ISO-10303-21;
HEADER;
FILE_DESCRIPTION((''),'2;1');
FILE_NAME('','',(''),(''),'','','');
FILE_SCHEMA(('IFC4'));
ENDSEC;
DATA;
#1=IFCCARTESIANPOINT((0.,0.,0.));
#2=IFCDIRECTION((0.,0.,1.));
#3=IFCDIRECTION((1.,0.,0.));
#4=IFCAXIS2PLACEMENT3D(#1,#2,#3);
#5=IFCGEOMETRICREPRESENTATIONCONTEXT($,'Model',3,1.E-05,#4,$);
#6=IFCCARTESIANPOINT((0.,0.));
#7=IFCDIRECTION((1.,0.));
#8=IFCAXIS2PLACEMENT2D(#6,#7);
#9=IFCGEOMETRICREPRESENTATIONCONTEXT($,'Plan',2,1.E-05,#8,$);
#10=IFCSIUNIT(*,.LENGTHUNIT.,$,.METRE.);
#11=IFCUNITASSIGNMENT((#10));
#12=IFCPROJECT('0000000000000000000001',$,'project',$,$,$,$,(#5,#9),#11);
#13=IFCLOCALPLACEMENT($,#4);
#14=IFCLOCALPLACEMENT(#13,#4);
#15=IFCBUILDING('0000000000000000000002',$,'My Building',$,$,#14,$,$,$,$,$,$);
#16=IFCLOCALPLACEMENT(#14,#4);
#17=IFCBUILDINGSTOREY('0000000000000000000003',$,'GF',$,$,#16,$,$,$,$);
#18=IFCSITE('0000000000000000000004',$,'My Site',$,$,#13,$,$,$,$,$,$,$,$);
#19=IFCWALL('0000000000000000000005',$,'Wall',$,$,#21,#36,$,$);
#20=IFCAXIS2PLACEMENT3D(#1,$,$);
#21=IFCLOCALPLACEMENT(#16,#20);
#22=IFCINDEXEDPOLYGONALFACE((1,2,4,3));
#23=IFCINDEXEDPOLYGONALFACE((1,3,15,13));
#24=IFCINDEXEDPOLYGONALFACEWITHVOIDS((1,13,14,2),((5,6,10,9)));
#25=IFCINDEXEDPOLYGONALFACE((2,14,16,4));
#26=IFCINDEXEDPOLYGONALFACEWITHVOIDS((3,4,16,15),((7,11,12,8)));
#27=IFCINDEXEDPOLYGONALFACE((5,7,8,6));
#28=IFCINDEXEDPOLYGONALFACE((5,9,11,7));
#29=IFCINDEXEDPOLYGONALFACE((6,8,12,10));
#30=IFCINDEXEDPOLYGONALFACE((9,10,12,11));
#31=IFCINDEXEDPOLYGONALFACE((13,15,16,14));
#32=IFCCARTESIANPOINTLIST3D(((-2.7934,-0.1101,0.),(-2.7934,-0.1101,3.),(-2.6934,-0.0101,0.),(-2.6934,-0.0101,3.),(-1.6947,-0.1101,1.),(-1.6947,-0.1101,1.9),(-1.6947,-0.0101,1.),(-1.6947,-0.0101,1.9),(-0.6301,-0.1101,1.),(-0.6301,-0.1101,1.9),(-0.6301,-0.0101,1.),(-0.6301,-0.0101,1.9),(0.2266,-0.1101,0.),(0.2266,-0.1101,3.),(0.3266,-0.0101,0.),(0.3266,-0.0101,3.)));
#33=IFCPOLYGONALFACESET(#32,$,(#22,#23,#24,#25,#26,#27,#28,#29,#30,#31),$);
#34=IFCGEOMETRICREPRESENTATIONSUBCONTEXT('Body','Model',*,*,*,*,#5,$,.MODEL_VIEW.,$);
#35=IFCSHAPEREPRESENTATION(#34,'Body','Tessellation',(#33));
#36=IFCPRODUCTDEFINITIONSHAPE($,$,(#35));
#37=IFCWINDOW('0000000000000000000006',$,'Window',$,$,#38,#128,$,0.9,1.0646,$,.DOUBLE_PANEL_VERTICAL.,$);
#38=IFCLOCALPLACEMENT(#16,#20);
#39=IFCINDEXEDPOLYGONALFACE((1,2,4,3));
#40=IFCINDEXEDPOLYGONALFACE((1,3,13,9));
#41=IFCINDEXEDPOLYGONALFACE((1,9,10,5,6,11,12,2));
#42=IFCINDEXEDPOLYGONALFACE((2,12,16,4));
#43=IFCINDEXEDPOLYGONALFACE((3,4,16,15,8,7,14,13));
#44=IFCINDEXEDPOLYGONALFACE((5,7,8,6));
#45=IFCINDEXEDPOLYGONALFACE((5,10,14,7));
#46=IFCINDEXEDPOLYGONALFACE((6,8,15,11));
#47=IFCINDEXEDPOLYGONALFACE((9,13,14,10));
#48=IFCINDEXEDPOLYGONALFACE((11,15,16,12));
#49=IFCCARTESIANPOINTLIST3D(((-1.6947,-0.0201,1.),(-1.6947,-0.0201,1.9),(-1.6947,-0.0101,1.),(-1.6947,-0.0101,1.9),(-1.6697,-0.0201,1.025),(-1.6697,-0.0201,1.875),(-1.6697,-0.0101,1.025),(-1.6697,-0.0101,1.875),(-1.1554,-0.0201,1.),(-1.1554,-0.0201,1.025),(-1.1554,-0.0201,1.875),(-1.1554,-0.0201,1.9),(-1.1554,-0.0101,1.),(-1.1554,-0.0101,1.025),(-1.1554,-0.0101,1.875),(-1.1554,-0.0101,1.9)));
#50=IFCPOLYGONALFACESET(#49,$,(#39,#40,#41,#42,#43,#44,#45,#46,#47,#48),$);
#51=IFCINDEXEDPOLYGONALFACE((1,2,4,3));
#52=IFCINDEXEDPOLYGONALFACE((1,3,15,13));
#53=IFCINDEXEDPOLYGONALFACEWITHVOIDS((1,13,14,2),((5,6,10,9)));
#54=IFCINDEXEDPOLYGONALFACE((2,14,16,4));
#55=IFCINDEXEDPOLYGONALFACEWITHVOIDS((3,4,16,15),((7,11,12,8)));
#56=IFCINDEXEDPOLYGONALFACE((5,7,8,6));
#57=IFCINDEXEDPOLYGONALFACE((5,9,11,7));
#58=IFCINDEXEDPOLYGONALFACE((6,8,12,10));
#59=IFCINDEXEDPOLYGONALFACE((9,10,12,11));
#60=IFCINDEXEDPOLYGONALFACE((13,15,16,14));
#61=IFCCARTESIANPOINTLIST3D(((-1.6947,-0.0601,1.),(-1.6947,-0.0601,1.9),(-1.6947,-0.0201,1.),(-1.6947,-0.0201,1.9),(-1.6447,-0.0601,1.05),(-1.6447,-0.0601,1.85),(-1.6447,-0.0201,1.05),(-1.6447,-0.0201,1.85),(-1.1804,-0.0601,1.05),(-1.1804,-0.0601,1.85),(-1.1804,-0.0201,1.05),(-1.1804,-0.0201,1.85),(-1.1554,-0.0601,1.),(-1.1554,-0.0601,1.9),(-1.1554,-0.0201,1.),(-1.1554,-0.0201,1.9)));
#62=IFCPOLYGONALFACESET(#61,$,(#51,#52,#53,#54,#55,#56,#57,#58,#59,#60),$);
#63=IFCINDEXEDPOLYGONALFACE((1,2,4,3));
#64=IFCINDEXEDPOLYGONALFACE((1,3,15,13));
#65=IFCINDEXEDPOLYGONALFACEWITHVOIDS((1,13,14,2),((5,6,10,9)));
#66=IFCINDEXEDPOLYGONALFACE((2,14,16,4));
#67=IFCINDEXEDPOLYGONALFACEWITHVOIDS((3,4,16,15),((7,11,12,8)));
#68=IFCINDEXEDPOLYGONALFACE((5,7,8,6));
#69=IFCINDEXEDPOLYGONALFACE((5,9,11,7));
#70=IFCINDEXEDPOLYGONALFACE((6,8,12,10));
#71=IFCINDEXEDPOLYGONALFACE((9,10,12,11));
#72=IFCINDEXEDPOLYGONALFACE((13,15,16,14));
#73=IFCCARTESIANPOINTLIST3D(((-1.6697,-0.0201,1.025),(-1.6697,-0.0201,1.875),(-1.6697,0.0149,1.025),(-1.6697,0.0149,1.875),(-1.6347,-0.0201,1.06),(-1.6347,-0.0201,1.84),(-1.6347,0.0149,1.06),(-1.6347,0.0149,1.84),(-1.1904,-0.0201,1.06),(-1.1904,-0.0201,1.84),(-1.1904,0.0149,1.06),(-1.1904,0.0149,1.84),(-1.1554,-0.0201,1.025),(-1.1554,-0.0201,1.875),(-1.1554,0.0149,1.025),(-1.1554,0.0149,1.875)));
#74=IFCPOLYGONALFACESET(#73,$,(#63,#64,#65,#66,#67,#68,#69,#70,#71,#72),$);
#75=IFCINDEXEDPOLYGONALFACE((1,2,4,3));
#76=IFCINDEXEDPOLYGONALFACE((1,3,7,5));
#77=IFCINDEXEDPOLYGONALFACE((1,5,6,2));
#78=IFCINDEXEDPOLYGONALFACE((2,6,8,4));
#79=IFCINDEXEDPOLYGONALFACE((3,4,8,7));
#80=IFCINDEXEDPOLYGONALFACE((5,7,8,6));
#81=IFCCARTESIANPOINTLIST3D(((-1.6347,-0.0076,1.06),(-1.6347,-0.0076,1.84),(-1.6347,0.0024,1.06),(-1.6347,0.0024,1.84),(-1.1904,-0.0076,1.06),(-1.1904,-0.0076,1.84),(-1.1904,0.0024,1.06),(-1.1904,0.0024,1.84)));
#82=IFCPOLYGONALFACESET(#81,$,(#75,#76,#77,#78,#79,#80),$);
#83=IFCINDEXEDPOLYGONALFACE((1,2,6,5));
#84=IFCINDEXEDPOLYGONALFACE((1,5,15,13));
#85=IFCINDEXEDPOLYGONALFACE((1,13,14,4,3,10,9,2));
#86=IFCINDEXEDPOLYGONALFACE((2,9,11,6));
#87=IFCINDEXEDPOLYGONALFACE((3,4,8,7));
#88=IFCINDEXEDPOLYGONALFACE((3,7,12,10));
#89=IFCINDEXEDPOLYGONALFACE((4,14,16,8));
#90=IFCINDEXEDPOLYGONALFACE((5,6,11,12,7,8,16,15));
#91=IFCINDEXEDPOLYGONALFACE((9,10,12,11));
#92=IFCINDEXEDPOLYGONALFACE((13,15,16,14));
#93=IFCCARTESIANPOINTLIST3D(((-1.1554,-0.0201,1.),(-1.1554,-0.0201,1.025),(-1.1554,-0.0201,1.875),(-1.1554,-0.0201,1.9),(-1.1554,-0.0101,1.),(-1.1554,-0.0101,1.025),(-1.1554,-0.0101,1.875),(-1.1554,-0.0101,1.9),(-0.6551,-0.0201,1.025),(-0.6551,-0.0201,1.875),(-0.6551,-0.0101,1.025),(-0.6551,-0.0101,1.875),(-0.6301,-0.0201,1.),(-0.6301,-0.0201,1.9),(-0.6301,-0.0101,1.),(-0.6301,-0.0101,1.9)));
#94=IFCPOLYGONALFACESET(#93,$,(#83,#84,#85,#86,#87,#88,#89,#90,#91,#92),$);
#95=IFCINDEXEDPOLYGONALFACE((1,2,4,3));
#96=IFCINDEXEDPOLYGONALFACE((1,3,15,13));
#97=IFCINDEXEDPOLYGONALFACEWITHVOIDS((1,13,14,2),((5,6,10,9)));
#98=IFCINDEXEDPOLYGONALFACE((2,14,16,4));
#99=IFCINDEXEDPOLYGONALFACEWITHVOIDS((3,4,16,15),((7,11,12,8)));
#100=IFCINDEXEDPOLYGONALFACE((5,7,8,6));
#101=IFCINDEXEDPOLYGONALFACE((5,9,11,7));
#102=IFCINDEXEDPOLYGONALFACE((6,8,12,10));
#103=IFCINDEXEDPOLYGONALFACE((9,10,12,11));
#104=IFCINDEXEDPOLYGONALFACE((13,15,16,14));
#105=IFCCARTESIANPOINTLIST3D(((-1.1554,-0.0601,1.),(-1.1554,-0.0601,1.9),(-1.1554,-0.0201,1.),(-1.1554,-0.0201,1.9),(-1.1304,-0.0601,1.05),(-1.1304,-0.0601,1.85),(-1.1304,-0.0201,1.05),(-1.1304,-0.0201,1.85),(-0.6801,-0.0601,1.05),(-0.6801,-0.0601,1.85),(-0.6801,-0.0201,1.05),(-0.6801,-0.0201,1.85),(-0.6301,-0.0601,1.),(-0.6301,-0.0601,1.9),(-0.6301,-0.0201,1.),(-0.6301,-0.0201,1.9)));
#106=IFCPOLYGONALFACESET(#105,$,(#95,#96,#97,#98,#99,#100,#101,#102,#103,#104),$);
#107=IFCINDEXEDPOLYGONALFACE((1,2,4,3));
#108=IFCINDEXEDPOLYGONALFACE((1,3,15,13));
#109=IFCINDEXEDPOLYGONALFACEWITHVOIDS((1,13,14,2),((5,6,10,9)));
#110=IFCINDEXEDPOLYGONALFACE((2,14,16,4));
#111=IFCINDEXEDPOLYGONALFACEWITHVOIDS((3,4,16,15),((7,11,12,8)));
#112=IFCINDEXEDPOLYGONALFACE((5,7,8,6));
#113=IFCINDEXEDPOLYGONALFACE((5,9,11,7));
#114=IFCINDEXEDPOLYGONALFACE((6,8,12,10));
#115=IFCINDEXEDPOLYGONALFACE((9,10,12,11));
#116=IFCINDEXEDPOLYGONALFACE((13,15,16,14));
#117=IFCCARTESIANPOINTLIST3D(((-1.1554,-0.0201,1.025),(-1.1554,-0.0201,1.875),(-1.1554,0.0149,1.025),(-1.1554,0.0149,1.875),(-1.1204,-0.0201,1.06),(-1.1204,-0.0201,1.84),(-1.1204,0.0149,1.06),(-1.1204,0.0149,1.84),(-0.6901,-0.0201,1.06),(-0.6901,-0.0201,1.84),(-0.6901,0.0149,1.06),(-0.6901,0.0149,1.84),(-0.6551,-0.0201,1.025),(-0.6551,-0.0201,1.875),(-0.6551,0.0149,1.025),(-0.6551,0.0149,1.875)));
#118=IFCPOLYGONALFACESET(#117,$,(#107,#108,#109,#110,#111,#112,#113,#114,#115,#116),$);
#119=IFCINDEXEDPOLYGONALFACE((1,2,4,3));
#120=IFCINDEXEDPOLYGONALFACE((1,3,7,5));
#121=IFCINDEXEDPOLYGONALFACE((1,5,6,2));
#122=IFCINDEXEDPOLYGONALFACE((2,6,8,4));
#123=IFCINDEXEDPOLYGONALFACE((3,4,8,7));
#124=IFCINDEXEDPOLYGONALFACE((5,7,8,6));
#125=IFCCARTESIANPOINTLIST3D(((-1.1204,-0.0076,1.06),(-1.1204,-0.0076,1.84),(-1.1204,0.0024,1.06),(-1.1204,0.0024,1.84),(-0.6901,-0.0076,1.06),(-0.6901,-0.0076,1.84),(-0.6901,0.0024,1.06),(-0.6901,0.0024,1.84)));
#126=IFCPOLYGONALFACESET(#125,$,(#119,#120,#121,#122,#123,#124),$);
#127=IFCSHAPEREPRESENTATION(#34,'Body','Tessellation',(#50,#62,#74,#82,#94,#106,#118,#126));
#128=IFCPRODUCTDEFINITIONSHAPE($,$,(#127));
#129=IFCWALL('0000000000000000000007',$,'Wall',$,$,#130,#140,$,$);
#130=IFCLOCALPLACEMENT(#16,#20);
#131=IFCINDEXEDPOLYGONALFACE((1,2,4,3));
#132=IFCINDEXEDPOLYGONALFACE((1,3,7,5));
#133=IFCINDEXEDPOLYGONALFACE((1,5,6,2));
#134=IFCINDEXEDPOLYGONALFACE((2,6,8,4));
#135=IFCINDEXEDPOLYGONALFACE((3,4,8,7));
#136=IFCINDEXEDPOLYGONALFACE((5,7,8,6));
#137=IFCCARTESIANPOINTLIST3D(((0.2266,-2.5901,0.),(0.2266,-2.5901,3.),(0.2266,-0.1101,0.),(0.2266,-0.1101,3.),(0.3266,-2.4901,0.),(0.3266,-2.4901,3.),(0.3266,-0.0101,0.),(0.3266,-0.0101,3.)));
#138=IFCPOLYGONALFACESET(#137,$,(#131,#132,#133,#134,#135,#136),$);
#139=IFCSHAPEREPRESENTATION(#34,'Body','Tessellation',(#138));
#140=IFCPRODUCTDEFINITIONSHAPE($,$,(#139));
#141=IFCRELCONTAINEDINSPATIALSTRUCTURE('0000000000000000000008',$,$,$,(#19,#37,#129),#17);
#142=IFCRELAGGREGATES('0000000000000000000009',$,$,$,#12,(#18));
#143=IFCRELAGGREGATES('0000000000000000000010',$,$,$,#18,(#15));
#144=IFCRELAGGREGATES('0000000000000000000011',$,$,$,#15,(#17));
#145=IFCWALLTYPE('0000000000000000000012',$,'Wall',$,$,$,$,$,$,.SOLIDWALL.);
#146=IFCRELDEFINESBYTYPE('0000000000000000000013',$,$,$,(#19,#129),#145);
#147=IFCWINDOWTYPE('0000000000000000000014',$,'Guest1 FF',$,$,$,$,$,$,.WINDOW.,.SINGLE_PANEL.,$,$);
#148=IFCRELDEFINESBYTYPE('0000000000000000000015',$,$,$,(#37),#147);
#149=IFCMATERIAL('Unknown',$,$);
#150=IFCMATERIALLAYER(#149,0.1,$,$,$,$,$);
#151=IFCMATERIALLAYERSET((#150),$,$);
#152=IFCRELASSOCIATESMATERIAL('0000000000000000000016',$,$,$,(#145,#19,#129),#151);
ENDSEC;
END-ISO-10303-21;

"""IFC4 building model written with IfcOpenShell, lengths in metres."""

from ifc_helpers import new_model, entity, si_unit, frame, origin_with_axes, origin_2d_with_axis, place, context, subcontext, project, spatial, line, indexed_curve, outline, extrude, shape, source, transform, mapped, material, layer, layer_set, layer_usage, type_object, type_shapes, element, fill, save


model = new_model("IFC4")

# Units and contexts
model_context = context("Model", 3, precision=1e-05, world=origin_with_axes())
plan_context = context("Plan", 2, precision=1e-05, world=origin_2d_with_axis())
body_context_1 = subcontext(model_context, "Body", "Model", "MODEL_VIEW")
body_context_2 = subcontext(plan_context, "Body", "Plan", "PLAN_VIEW")
ifc_project = project(units=[si_unit("LENGTHUNIT", "METRE")], contexts=[model_context, plan_context])

# Site, building, storey
site_placement = place(None, origin_with_axes())
site = spatial("IfcSite", under=ifc_project, at=site_placement, Name="My Site")
building_placement = place(site_placement, origin_with_axes())
building = spatial("IfcBuilding", under=site, at=building_placement, Name="My Building")
storey_placement = place(building_placement, origin_with_axes())
storey = spatial("IfcBuildingStorey", under=building, at=storey_placement, Name="GF")

# Shared definitions
ifc_material = material(Name="Unknown")
ifc_layer = layer(ifc_material, 0.1)
ifc_layer_set = layer_set([ifc_layer])
wall_type = type_object("IfcWallType", Name="Wall", PredefinedType="SOLIDWALL", material=ifc_layer_set)

# Wall, opening, window
ifc_layer_usage_1 = layer_usage(ifc_layer_set, "AXIS2", "POSITIVE", 0.0)
wall_1_placement = place(storey_placement, frame((-2.7934, -0.1101, 0.0), z_axis=(0.0, 0.0, 1.0), x_axis=(1.0, 0.0, 0.0)))
wall_1 = element("IfcWall", 1, at=wall_1_placement, inside=storey, type_object=wall_type, material=ifc_layer_usage_1, Name="Wall", context=body_context_1, shape_type="SweptSolid", body=[
    extrude(outline(indexed_curve([(0.0, 0.0), (0.1, 0.1), (3.12, 0.1), (3.02, 0.0)], segments=[line(1, 2, 3, 4, 1)])), origin_with_axes(), (0.0, 0.0, 1.0), 3.0),
])
shared_shape_1 = source(origin_with_axes(), body_context_1, "Body", "SweptSolid", [
    extrude(outline(indexed_curve([(0.0, 0.0), (1.0646, 0.0), (1.0646, 0.9), (0.0, 0.9)], segments=[line(1, 2, 3, 4, 1)])), frame((0.0, -0.6, 0.0), z_axis=(0.0, -1.0, 0.0), x_axis=(1.0, 0.0, 0.0)), (0.0, 0.0, -1.0), 1.2),
])
opening_1_placement = place(wall_1_placement, frame((1.0987, 0.0, 1.0), z_axis=(0.0, 0.0, 1.0), x_axis=(1.0, 0.0, 0.0)))
opening_1 = element("IfcOpeningElement", 2, at=opening_1_placement, cuts=wall_1, PredefinedType="OPENING", context=body_context_1, shape_type="MappedRepresentation", body=[
    mapped(shared_shape_1, transform((0.0, 0.0, 0.0), x_axis=(1.0, 0.0, 0.0), y_axis=(0.0, 1.0, 0.0), z_axis=(0.0, 0.0, 1.0), scale=1.0)),
])
window_type_1 = type_object("IfcWindowType", Name="Guest1 FF", PartitioningType="SINGLE_PANEL", PredefinedType="WINDOW")
shared_shape_2 = source(origin_with_axes(), body_context_1, "Body", "SweptSolid", [
    extrude(outline(indexed_curve([(0.5393, 0.0), (0.0, 0.0), (0.0, 0.9), (0.5393, 0.9), (0.5393, 0.875), (0.025, 0.875), (0.025, 0.025), (0.5393, 0.025)], segments=[line(1, 2, 3, 4, 5, 6, 7, 8, 1)])), frame((0.0, 0.09, 0.0), z_axis=(0.0, -1.0, 0.0), x_axis=(1.0, 0.0, 0.0)), (0.0, 0.0, -1.0), 0.01),
    extrude(outline(indexed_curve([(0.0, 0.0), (0.5393, 0.0), (0.5393, 0.9), (0.0, 0.9)], segments=[line(1, 2, 3, 4, 1)]), holes=[indexed_curve([(0.05, 0.05), (0.5143, 0.05), (0.5143, 0.85), (0.05, 0.85)], segments=[line(1, 2, 3, 4, 1)])]), frame((0.0, 0.05, 0.0), z_axis=(0.0, -1.0, 0.0), x_axis=(1.0, 0.0, 0.0)), (0.0, 0.0, -1.0), 0.04),
    extrude(outline(indexed_curve([(0.0, 0.0), (0.5143, 0.0), (0.5143, 0.85), (0.0, 0.85)], segments=[line(1, 2, 3, 4, 1)]), holes=[indexed_curve([(0.035, 0.035), (0.4793, 0.035), (0.4793, 0.815), (0.035, 0.815)], segments=[line(1, 2, 3, 4, 1)])]), frame((0.025, 0.09, 0.025), z_axis=(0.0, -1.0, 0.0), x_axis=(1.0, 0.0, 0.0)), (0.0, 0.0, -1.0), 0.035),
    extrude(outline(indexed_curve([(0.035, 0.035), (0.4793, 0.035), (0.4793, 0.815), (0.035, 0.815)], segments=[line(1, 2, 3, 4, 1)])), frame((0.025, 0.1025, 0.025), z_axis=(0.0, -1.0, 0.0), x_axis=(1.0, 0.0, 0.0)), (0.0, 0.0, -1.0), 0.01),
    extrude(outline(indexed_curve([(0.0, 0.9), (0.5253, 0.9), (0.5253, 0.0), (0.0, 0.0), (0.0, 0.025), (0.5003, 0.025), (0.5003, 0.875), (0.0, 0.875)], segments=[line(1, 2, 3, 4, 5, 6, 7, 8, 1)])), frame((0.5393, 0.09, 0.0), z_axis=(0.0, -1.0, 0.0), x_axis=(1.0, 0.0, 0.0)), (0.0, 0.0, -1.0), 0.01),
    extrude(outline(indexed_curve([(0.0, 0.0), (0.5253, 0.0), (0.5253, 0.9), (0.0, 0.9)], segments=[line(1, 2, 3, 4, 1)]), holes=[indexed_curve([(0.025, 0.05), (0.4753, 0.05), (0.4753, 0.85), (0.025, 0.85)], segments=[line(1, 2, 3, 4, 1)])]), frame((0.5393, 0.05, 0.0), z_axis=(0.0, -1.0, 0.0), x_axis=(1.0, 0.0, 0.0)), (0.0, 0.0, -1.0), 0.04),
    extrude(outline(indexed_curve([(0.0, 0.0), (0.5003, 0.0), (0.5003, 0.85), (0.0, 0.85)], segments=[line(1, 2, 3, 4, 1)]), holes=[indexed_curve([(0.035, 0.035), (0.4653, 0.035), (0.4653, 0.815), (0.035, 0.815)], segments=[line(1, 2, 3, 4, 1)])]), frame((0.5393, 0.09, 0.025), z_axis=(0.0, -1.0, 0.0), x_axis=(1.0, 0.0, 0.0)), (0.0, 0.0, -1.0), 0.035),
    extrude(outline(indexed_curve([(0.035, 0.035), (0.4653, 0.035), (0.4653, 0.815), (0.035, 0.815)], segments=[line(1, 2, 3, 4, 1)])), frame((0.5393, 0.1025, 0.025), z_axis=(0.0, -1.0, 0.0), x_axis=(1.0, 0.0, 0.0)), (0.0, 0.0, -1.0), 0.01),
])
shared_shape_3 = source(origin_with_axes(), body_context_2, "Body", "Curve2D", [
    entity("IfcIndexedPolyCurve", entity("IfcCartesianPointList2D", [[0.05, 0.05], [0.5143, 0.05]])),
    entity("IfcIndexedPolyCurve", entity("IfcCartesianPointList2D", [[0.0, 0.1], [0.025, 0.1], [0.025, 0.09], [0.05, 0.09], [0.05, 0.05], [0.0, 0.05]]), [entity("IfcLineIndex", [1, 2, 3, 4, 5, 6, 1])]),
    entity("IfcIndexedPolyCurve", entity("IfcCartesianPointList2D", [[0.5393, 0.1], [0.5393, 0.1], [0.5393, 0.09], [0.5143, 0.09], [0.5143, 0.05], [0.5393, 0.05]])),
    entity("IfcIndexedPolyCurve", entity("IfcCartesianPointList2D", [[0.025, 0.09], [0.06, 0.09], [0.06, 0.125], [0.025, 0.125]]), [entity("IfcLineIndex", [1, 2, 3, 4, 1])]),
    entity("IfcIndexedPolyCurve", entity("IfcCartesianPointList2D", [[0.5393, 0.09], [0.5043, 0.09], [0.5043, 0.125], [0.5393, 0.125]]), [entity("IfcLineIndex", [1, 2, 3, 4, 1])]),
    entity("IfcIndexedPolyCurve", entity("IfcCartesianPointList2D", [[0.06, 0.09], [0.5043, 0.09]])),
    entity("IfcIndexedPolyCurve", entity("IfcCartesianPointList2D", [[0.06, 0.125], [0.5043, 0.125]])),
    entity("IfcIndexedPolyCurve", entity("IfcCartesianPointList2D", [[0.06, 0.1075], [0.5043, 0.1075]])),
    entity("IfcIndexedPolyCurve", entity("IfcCartesianPointList2D", [[0.5643, 0.05], [1.0146, 0.05]])),
    entity("IfcIndexedPolyCurve", entity("IfcCartesianPointList2D", [[0.5393, 0.1], [0.5393, 0.1], [0.5393, 0.09], [0.5643, 0.09], [0.5643, 0.05], [0.5393, 0.05]])),
    entity("IfcIndexedPolyCurve", entity("IfcCartesianPointList2D", [[1.0646, 0.1], [1.0396, 0.1], [1.0396, 0.09], [1.0146, 0.09], [1.0146, 0.05], [1.0646, 0.05]]), [entity("IfcLineIndex", [1, 2, 3, 4, 5, 6, 1])]),
    entity("IfcIndexedPolyCurve", entity("IfcCartesianPointList2D", [[0.5393, 0.09], [0.5743, 0.09], [0.5743, 0.125], [0.5393, 0.125]]), [entity("IfcLineIndex", [1, 2, 3, 4, 1])]),
    entity("IfcIndexedPolyCurve", entity("IfcCartesianPointList2D", [[1.0396, 0.09], [1.0046, 0.09], [1.0046, 0.125], [1.0396, 0.125]]), [entity("IfcLineIndex", [1, 2, 3, 4, 1])]),
    entity("IfcIndexedPolyCurve", entity("IfcCartesianPointList2D", [[0.5743, 0.09], [1.0046, 0.09]])),
    entity("IfcIndexedPolyCurve", entity("IfcCartesianPointList2D", [[0.5743, 0.125], [1.0046, 0.125]])),
    entity("IfcIndexedPolyCurve", entity("IfcCartesianPointList2D", [[0.5743, 0.1075], [1.0046, 0.1075]])),
])
type_shapes(window_type_1, [shared_shape_2, shared_shape_3])
window_1_placement = place(opening_1_placement, origin_with_axes())
window_1 = element("IfcWindow", 3, at=window_1_placement, inside=storey, type_object=window_type_1, Name="Window", OverallHeight=0.9, OverallWidth=1.0646, PartitioningType="DOUBLE_PANEL_VERTICAL", shapes=[
    shape(body_context_1, "Body", "MappedRepresentation", [mapped(shared_shape_2, transform((0.0, 0.0, 0.0), x_axis=(1.0, 0.0, 0.0), y_axis=(0.0, 1.0, 0.0), z_axis=(0.0, 0.0, 1.0), scale=1.0))]),
    shape(body_context_2, "Body", "MappedRepresentation", [mapped(shared_shape_3, transform((0.0, 0.0, 0.0), x_axis=(1.0, 0.0, 0.0), y_axis=(0.0, 1.0, 0.0), z_axis=(0.0, 0.0, 1.0), scale=1.0))]),
])
fill(opening_1, window_1)

# Wall
ifc_layer_usage_2 = layer_usage(ifc_layer_set, "AXIS2", "POSITIVE", 0.0)
wall_2_placement = place(storey_placement, frame((0.2266, -0.1101, 0.0), z_axis=(0.0, 0.0, 1.0), x_axis=(0.0, -1.0, 0.0)))
element("IfcWall", 4, at=wall_2_placement, inside=storey, type_object=wall_type, material=ifc_layer_usage_2, Name="Wall", context=body_context_1, shape_type="SweptSolid", body=[
    extrude(outline(indexed_curve([(0.0, 0.0), (-0.1, 0.1), (2.38, 0.1), (2.48, 0.0)], segments=[line(1, 2, 3, 4, 1)])), origin_with_axes(), (0.0, 0.0, 1.0), 3.0),
])

save(model, "model.ifc")
